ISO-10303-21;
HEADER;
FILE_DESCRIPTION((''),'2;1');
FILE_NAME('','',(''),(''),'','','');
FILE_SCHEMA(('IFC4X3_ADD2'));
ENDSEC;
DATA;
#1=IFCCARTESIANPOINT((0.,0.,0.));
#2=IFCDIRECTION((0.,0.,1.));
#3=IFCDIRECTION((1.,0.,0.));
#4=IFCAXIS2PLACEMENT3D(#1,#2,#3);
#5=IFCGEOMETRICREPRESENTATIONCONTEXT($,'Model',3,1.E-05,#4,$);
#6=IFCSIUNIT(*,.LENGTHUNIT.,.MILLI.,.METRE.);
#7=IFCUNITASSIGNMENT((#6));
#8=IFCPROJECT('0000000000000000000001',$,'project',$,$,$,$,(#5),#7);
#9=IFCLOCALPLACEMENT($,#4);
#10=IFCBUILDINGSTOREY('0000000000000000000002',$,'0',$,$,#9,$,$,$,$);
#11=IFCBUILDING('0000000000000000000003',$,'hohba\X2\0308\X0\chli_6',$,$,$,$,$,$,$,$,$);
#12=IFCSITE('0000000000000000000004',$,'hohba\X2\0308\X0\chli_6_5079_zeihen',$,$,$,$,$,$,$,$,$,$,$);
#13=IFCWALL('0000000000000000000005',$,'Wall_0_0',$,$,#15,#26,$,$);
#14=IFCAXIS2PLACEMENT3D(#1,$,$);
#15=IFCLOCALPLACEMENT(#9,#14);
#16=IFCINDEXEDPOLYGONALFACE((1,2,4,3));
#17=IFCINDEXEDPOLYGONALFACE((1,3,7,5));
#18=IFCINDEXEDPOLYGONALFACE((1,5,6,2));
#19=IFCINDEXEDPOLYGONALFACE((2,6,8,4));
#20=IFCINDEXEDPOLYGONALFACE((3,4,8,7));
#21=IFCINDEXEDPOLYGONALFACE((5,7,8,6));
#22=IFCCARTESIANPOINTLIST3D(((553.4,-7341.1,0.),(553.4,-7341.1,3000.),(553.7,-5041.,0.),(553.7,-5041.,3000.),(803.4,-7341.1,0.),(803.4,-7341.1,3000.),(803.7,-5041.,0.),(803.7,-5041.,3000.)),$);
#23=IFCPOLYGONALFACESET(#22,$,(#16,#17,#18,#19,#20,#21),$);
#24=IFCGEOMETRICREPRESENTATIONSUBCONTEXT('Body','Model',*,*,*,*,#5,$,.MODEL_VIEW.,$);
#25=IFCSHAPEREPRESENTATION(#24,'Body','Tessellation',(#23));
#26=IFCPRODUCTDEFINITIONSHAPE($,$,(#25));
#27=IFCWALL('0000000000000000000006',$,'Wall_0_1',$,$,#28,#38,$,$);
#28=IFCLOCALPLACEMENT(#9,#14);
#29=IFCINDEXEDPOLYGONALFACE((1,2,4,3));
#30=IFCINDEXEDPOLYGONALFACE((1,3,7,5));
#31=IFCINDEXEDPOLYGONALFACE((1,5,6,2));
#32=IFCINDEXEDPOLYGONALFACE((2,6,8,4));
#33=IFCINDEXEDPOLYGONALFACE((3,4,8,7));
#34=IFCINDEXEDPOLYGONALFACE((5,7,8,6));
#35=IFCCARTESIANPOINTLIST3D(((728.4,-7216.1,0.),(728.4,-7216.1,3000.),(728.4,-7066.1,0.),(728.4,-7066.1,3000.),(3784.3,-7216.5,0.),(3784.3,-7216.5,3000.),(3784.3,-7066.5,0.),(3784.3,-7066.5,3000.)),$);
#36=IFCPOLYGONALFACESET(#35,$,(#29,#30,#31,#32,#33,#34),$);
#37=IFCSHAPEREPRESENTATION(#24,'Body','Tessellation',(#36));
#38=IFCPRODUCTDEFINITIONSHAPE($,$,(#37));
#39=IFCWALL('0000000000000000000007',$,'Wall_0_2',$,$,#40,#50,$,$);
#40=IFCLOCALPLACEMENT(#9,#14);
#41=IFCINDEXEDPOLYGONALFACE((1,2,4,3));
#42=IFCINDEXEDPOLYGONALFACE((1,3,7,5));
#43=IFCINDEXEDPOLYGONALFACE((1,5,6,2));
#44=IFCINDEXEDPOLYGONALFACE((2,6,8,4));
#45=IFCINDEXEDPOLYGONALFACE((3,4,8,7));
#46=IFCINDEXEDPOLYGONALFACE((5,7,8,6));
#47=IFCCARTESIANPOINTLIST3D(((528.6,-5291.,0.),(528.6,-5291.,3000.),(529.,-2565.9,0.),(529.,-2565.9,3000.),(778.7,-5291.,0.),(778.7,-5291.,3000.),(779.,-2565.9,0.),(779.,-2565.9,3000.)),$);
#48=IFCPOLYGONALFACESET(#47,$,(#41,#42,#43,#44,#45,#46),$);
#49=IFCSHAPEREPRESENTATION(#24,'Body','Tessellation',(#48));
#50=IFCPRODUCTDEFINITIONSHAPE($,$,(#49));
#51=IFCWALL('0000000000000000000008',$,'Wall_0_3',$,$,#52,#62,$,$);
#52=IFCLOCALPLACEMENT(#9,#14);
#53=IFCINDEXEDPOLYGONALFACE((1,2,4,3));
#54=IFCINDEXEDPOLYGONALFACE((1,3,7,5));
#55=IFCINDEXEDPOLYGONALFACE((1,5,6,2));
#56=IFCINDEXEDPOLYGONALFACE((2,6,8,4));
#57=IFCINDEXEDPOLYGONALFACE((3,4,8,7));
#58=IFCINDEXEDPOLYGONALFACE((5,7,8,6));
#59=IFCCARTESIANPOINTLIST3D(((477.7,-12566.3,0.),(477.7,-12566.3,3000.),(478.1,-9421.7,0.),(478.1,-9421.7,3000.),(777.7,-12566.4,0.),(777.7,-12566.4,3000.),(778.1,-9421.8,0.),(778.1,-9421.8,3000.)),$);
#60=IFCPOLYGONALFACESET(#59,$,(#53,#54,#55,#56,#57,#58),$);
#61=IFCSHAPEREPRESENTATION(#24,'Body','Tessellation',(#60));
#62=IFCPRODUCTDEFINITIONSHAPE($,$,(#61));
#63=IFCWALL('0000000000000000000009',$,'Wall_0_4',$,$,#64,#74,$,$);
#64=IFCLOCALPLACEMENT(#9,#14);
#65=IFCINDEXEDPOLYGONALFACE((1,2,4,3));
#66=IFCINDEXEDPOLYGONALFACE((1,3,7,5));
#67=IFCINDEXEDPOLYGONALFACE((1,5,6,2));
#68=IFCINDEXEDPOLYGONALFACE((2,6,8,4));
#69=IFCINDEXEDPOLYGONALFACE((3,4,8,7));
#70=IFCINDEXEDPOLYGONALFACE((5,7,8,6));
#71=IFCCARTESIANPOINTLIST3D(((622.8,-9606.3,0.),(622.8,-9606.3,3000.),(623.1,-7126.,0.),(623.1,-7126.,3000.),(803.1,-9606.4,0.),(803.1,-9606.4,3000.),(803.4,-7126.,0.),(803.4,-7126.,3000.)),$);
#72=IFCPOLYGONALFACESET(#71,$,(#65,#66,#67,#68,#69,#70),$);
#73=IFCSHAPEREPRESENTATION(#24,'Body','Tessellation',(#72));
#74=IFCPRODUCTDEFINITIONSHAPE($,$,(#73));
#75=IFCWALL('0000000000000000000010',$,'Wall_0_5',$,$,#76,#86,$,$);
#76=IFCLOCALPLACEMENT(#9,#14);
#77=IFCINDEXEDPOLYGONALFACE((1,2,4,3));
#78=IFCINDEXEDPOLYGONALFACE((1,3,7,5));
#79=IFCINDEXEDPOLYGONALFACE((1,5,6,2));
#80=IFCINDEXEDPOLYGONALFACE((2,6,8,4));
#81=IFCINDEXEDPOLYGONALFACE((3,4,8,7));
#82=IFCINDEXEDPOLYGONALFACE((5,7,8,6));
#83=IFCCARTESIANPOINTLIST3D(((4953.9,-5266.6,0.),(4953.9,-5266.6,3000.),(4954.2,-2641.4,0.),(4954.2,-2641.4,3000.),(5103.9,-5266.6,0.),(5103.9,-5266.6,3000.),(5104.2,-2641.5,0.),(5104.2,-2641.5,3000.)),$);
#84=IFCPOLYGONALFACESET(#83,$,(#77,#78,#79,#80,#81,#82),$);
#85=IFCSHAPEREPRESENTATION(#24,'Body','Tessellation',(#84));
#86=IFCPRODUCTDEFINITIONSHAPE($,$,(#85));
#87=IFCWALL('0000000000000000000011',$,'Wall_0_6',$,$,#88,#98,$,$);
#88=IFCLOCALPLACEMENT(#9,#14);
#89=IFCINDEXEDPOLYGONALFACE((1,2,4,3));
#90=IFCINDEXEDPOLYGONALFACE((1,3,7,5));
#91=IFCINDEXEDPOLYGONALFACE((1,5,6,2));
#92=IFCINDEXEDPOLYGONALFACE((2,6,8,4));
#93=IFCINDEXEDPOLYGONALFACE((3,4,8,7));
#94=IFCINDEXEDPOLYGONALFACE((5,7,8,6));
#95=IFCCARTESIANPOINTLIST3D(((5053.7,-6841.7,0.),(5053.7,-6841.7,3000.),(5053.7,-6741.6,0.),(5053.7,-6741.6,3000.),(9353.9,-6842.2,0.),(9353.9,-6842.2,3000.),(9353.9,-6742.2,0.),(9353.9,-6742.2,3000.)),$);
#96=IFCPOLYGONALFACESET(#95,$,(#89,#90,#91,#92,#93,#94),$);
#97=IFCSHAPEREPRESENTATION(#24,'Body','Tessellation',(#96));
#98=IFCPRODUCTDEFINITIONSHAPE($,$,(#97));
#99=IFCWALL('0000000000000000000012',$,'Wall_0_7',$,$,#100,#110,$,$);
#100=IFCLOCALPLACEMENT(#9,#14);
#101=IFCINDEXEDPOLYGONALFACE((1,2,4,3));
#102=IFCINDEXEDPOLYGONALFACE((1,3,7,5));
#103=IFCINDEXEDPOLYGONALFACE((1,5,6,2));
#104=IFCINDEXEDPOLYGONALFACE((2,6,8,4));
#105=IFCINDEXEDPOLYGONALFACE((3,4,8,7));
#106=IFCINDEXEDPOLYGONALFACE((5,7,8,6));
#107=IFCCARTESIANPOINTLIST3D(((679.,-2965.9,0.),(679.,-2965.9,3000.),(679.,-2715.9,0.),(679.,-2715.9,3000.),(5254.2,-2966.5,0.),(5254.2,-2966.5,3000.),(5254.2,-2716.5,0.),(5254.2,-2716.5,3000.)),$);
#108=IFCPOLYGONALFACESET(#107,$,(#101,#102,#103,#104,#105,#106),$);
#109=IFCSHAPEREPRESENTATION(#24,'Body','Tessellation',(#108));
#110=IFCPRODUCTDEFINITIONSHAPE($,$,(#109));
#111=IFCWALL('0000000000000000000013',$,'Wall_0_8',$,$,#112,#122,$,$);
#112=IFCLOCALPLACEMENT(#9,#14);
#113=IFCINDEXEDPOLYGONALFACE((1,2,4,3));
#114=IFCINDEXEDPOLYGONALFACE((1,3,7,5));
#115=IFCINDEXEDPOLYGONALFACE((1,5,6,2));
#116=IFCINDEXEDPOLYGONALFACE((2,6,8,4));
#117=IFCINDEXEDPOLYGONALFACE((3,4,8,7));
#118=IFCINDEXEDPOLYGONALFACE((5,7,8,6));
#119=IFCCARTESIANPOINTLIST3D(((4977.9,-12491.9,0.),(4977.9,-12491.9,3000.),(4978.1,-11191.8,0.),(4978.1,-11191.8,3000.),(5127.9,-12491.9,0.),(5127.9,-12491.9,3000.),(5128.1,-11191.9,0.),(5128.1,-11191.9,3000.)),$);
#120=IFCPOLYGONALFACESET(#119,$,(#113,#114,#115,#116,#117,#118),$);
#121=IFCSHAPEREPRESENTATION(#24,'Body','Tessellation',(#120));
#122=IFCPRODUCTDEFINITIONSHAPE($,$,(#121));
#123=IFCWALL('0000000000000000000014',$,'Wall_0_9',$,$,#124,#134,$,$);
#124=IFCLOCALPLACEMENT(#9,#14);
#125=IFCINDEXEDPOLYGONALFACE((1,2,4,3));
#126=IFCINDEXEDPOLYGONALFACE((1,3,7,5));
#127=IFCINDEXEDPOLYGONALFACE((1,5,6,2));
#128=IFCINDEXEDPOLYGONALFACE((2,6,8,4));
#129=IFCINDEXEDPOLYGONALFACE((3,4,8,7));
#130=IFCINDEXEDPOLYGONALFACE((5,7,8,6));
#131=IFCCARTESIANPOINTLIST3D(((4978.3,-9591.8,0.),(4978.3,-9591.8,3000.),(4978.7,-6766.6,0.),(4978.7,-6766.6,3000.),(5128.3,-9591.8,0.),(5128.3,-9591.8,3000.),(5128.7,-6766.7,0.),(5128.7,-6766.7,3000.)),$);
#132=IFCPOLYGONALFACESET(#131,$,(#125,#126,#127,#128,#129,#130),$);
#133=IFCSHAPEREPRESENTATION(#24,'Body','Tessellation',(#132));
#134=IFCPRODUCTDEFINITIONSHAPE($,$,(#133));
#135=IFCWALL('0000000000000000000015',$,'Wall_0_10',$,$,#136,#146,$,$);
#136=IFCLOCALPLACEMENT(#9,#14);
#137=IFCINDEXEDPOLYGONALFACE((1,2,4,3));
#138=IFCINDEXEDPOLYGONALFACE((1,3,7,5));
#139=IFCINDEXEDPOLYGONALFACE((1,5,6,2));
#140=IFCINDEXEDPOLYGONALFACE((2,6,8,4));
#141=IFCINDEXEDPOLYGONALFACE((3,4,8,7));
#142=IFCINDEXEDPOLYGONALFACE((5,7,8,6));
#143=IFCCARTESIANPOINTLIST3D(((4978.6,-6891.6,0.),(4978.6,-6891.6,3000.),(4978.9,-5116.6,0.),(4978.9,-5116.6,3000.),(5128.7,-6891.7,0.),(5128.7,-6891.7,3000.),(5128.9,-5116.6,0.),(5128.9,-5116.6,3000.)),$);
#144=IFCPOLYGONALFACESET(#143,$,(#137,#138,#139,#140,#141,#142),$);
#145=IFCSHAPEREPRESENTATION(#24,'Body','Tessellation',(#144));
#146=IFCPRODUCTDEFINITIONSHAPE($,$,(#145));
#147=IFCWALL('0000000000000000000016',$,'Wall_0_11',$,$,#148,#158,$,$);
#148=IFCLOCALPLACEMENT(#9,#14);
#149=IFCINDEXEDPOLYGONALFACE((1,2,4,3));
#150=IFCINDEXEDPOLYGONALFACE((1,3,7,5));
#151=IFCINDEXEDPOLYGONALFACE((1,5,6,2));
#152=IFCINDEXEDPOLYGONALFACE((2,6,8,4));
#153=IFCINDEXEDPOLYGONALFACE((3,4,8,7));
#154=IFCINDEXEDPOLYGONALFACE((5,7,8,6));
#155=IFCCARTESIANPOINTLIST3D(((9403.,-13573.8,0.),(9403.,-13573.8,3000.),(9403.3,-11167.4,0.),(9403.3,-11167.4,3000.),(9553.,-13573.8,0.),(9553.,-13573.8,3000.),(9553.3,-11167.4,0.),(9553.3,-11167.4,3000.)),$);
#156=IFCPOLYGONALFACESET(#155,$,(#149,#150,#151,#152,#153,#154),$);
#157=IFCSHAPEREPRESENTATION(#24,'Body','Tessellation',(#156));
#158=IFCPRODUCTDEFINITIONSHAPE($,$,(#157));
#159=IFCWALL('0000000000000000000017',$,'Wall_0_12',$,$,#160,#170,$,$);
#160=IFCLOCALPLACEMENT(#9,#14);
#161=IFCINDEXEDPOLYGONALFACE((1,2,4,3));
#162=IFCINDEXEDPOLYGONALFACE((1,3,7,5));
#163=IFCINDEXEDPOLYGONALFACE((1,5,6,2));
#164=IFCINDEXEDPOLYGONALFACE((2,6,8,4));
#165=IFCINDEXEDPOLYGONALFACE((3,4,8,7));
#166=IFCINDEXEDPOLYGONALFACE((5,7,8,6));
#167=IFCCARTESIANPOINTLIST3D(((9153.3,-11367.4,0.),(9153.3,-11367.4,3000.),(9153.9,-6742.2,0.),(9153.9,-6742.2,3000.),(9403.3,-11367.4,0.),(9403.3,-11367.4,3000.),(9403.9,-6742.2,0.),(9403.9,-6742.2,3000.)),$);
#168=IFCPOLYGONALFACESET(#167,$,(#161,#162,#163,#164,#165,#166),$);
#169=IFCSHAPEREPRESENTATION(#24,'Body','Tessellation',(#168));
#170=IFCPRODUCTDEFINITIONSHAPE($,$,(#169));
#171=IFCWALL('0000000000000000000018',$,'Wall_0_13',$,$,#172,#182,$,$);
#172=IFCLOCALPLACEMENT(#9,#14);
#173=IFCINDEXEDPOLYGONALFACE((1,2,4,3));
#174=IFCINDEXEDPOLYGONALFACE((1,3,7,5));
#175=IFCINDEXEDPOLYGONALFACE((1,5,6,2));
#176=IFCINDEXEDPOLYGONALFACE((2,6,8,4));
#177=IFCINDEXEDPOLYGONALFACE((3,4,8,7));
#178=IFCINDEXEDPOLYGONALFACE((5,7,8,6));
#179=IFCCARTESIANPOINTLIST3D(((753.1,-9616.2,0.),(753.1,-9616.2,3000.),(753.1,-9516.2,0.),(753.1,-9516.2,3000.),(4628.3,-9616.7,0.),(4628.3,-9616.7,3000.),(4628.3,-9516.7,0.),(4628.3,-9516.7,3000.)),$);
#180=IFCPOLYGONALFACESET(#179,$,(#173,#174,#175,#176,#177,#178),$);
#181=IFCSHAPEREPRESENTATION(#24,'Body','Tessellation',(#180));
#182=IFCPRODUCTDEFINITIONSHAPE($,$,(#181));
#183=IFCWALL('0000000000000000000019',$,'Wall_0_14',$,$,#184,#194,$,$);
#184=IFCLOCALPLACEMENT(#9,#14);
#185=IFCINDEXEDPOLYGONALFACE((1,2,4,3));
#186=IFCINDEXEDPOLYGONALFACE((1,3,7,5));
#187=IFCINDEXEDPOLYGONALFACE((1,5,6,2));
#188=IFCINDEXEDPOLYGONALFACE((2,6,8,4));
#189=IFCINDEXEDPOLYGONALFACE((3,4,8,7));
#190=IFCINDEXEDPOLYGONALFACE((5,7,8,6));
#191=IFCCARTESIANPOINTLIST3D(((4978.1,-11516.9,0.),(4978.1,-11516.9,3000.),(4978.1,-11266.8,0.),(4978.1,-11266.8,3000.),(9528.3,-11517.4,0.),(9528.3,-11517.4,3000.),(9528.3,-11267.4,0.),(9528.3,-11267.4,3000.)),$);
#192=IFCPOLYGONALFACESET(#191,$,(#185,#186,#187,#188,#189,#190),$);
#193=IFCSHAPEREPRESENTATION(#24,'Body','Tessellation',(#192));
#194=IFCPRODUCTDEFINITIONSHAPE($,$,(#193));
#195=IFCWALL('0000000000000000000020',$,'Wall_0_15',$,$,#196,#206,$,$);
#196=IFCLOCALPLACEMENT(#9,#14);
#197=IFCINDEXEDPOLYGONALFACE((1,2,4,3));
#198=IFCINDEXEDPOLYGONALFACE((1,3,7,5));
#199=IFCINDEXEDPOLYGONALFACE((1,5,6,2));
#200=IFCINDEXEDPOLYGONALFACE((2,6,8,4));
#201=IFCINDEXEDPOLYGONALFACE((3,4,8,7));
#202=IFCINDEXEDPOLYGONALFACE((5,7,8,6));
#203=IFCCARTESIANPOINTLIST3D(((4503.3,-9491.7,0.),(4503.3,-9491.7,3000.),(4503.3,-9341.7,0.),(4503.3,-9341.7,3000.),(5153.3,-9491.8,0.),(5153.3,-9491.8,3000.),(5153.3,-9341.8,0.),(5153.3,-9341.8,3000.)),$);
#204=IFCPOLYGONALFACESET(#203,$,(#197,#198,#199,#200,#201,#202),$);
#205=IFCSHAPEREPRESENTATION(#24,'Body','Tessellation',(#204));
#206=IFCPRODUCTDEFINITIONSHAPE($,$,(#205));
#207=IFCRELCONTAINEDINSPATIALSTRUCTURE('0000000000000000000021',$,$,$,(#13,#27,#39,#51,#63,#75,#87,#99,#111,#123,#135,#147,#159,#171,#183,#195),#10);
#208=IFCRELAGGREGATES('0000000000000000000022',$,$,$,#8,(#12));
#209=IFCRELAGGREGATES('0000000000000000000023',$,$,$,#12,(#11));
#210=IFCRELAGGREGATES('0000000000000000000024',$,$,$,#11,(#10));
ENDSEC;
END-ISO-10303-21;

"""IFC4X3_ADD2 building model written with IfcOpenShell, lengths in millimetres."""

from ifc_helpers import new_model, si_unit, frame, origin_with_axes, place, context, subcontext, project, spatial, indexed_curve, outline, extrude, element, save


model = new_model("IFC4X3_ADD2")

# Units and contexts
model_context = context("Model", 3, precision=1e-05, world=origin_with_axes())
body_context = subcontext(model_context, "Body", "Model", "MODEL_VIEW")
ifc_project = project(units=[si_unit("LENGTHUNIT", "METRE", prefix="MILLI")], contexts=[model_context])

# Site, building, storey
site = spatial("IfcSite", under=ifc_project, Name="hohbächli_6_5079_zeihen")
building = spatial("IfcBuilding", under=site, Name="hohbächli_6")
storey_placement = place(None, origin_with_axes())
storey = spatial("IfcBuildingStorey", under=building, at=storey_placement, Name="0")

# Walls
wall_1_placement = place(storey_placement, frame((803.4, -7341.1, 0.0), z_axis=(0.0, 0.0, 1.0), x_axis=(0.000129, 1.0, 0.0)))
element("IfcWall", 1, at=wall_1_placement, inside=storey, Name="Wall_0_0", context=body_context, shape_type="SweptSolid", body=[
    extrude(outline(indexed_curve([(0.0, 0.0), (0.0, 250.0), (2300.1, 250.0), (2300.1, 0.0), (0.0, 0.0)], self_intersect=False)), origin_with_axes(), (0.0, 0.0, 1.0), 3000.0),
])
wall_2_placement = place(storey_placement, frame((728.4, -7216.1, 0.0), z_axis=(0.0, 0.0, 1.0), x_axis=(1.0, -0.000129, 0.0)))
element("IfcWall", 2, at=wall_2_placement, inside=storey, Name="Wall_0_1", context=body_context, shape_type="SweptSolid", body=[
    extrude(outline(indexed_curve([(0.0, 0.0), (0.0, 150.0), (3055.9, 150.0), (3055.9, 0.0), (0.0, 0.0)], self_intersect=False)), origin_with_axes(), (0.0, 0.0, 1.0), 3000.0),
])
wall_3_placement = place(storey_placement, frame((778.7, -5291.0, 0.0), z_axis=(0.0, 0.0, 1.0), x_axis=(0.000129, 1.0, 0.0)))
element("IfcWall", 3, at=wall_3_placement, inside=storey, Name="Wall_0_2", context=body_context, shape_type="SweptSolid", body=[
    extrude(outline(indexed_curve([(0.0, 0.0), (0.0, 250.0), (2725.1, 250.0), (2725.1, 0.0), (0.0, 0.0)], self_intersect=False)), origin_with_axes(), (0.0, 0.0, 1.0), 3000.0),
])
wall_4_placement = place(storey_placement, frame((777.7, -12566.4, 0.0), z_axis=(0.0, 0.0, 1.0), x_axis=(0.000129, 1.0, 0.0)))
element("IfcWall", 4, at=wall_4_placement, inside=storey, Name="Wall_0_3", context=body_context, shape_type="SweptSolid", body=[
    extrude(outline(indexed_curve([(0.0, 0.0), (0.0, 300.0), (3144.6, 300.0), (3144.6, 0.0), (0.0, 0.0)], self_intersect=False)), origin_with_axes(), (0.0, 0.0, 1.0), 3000.0),
])
wall_5_placement = place(storey_placement, frame((803.1, -9606.4, 0.0), z_axis=(0.0, 0.0, 1.0), x_axis=(0.000129, 1.0, 0.0)))
element("IfcWall", 5, at=wall_5_placement, inside=storey, Name="Wall_0_4", context=body_context, shape_type="SweptSolid", body=[
    extrude(outline(indexed_curve([(0.0, 0.0), (0.0, 180.3), (2480.4, 180.3), (2480.4, 0.0), (0.0, 0.0)], self_intersect=False)), origin_with_axes(), (0.0, 0.0, 1.0), 3000.0),
])
wall_6_placement = place(storey_placement, frame((5103.9, -5266.6, 0.0), z_axis=(0.0, 0.0, 1.0), x_axis=(0.000129, 1.0, 0.0)))
element("IfcWall", 6, at=wall_6_placement, inside=storey, Name="Wall_0_5", context=body_context, shape_type="SweptSolid", body=[
    extrude(outline(indexed_curve([(0.0, 0.0), (0.0, 150.0), (2625.1, 150.0), (2625.1, 0.0), (0.0, 0.0)], self_intersect=False)), origin_with_axes(), (0.0, 0.0, 1.0), 3000.0),
])
wall_7_placement = place(storey_placement, frame((5053.7, -6841.7, 0.0), z_axis=(0.0, 0.0, 1.0), x_axis=(1.0, -0.000129, 0.0)))
element("IfcWall", 7, at=wall_7_placement, inside=storey, Name="Wall_0_6", context=body_context, shape_type="SweptSolid", body=[
    extrude(outline(indexed_curve([(0.0, 0.0), (0.0, 100.0), (4300.2, 100.0), (4300.2, 0.0), (0.0, 0.0)], self_intersect=False)), origin_with_axes(), (0.0, 0.0, 1.0), 3000.0),
])
wall_8_placement = place(storey_placement, frame((5254.2, -2716.5, 0.0), z_axis=(0.0, 0.0, 1.0), x_axis=(-1.0, 0.000129, 0.0)))
element("IfcWall", 8, at=wall_8_placement, inside=storey, Name="Wall_0_7", context=body_context, shape_type="SweptSolid", body=[
    extrude(outline(indexed_curve([(0.0, 0.0), (0.0, 250.0), (4575.2, 250.0), (4575.2, 0.0), (0.0, 0.0)], self_intersect=False)), origin_with_axes(), (0.0, 0.0, 1.0), 3000.0),
])
wall_9_placement = place(storey_placement, frame((5127.9, -12491.9, 0.0), z_axis=(0.0, 0.0, 1.0), x_axis=(0.000129, 1.0, 0.0)))
element("IfcWall", 9, at=wall_9_placement, inside=storey, Name="Wall_0_8", context=body_context, shape_type="SweptSolid", body=[
    extrude(outline(indexed_curve([(0.0, 0.0), (0.0, 150.0), (1300.1, 150.0), (1300.1, 0.0), (0.0, 0.0)], self_intersect=False)), origin_with_axes(), (0.0, 0.0, 1.0), 3000.0),
])
wall_10_placement = place(storey_placement, frame((5128.3, -9591.8, 0.0), z_axis=(0.0, 0.0, 1.0), x_axis=(0.000129, 1.0, 0.0)))
element("IfcWall", 10, at=wall_10_placement, inside=storey, Name="Wall_0_9", context=body_context, shape_type="SweptSolid", body=[
    extrude(outline(indexed_curve([(0.0, 0.0), (0.0, 150.0), (2825.1, 150.0), (2825.1, 0.0), (0.0, 0.0)], self_intersect=False)), origin_with_axes(), (0.0, 0.0, 1.0), 3000.0),
])
wall_11_placement = place(storey_placement, frame((5128.7, -6891.7, 0.0), z_axis=(0.0, 0.0, 1.0), x_axis=(0.000129, 1.0, 0.0)))
element("IfcWall", 11, at=wall_11_placement, inside=storey, Name="Wall_0_10", context=body_context, shape_type="SweptSolid", body=[
    extrude(outline(indexed_curve([(0.0, 0.0), (0.0, 150.0), (1775.1, 150.0), (1775.1, 0.0), (0.0, 0.0)], self_intersect=False)), origin_with_axes(), (0.0, 0.0, 1.0), 3000.0),
])
wall_12_placement = place(storey_placement, frame((9403.3, -11167.4, 0.0), z_axis=(0.0, 0.0, 1.0), x_axis=(-0.000129, -1.0, 0.0)))
element("IfcWall", 12, at=wall_12_placement, inside=storey, Name="Wall_0_11", context=body_context, shape_type="SweptSolid", body=[
    extrude(outline(indexed_curve([(0.0, 0.0), (0.0, 150.0), (2406.4, 150.0), (2406.4, 0.0), (0.0, 0.0)], self_intersect=False)), origin_with_axes(), (0.0, 0.0, 1.0), 3000.0),
])
wall_13_placement = place(storey_placement, frame((9403.3, -11367.4, 0.0), z_axis=(0.0, 0.0, 1.0), x_axis=(0.000129, 1.0, 0.0)))
element("IfcWall", 13, at=wall_13_placement, inside=storey, Name="Wall_0_12", context=body_context, shape_type="SweptSolid", body=[
    extrude(outline(indexed_curve([(0.0, 0.0), (0.0, 250.0), (4625.2, 250.0), (4625.2, 0.0), (0.0, 0.0)], self_intersect=False)), origin_with_axes(), (0.0, 0.0, 1.0), 3000.0),
])
wall_14_placement = place(storey_placement, frame((4628.3, -9516.7, 0.0), z_axis=(0.0, 0.0, 1.0), x_axis=(-1.0, 0.000129, 0.0)))
element("IfcWall", 14, at=wall_14_placement, inside=storey, Name="Wall_0_13", context=body_context, shape_type="SweptSolid", body=[
    extrude(outline(indexed_curve([(0.0, 0.0), (0.0, 100.0), (3875.2, 100.0), (3875.2, 0.0), (0.0, 0.0)], self_intersect=False)), origin_with_axes(), (0.0, 0.0, 1.0), 3000.0),
])
wall_15_placement = place(storey_placement, frame((9528.3, -11267.4, 0.0), z_axis=(0.0, 0.0, 1.0), x_axis=(-1.0, 0.000129, 0.0)))
element("IfcWall", 15, at=wall_15_placement, inside=storey, Name="Wall_0_14", context=body_context, shape_type="SweptSolid", body=[
    extrude(outline(indexed_curve([(0.0, 0.0), (0.0, 250.0), (4550.2, 250.0), (4550.2, 0.0), (0.0, 0.0)], self_intersect=False)), origin_with_axes(), (0.0, 0.0, 1.0), 3000.0),
])
wall_16_placement = place(storey_placement, frame((4503.3, -9491.7, 0.0), z_axis=(0.0, 0.0, 1.0), x_axis=(1.0, -0.000129, 0.0)))
element("IfcWall", 16, at=wall_16_placement, inside=storey, Name="Wall_0_15", context=body_context, shape_type="SweptSolid", body=[
    extrude(outline(indexed_curve([(0.0, 0.0), (0.0, 150.0), (650.0, 150.0), (650.0, 0.0), (0.0, 0.0)], self_intersect=False)), origin_with_axes(), (0.0, 0.0, 1.0), 3000.0),
])

save(model, "model.ifc")
